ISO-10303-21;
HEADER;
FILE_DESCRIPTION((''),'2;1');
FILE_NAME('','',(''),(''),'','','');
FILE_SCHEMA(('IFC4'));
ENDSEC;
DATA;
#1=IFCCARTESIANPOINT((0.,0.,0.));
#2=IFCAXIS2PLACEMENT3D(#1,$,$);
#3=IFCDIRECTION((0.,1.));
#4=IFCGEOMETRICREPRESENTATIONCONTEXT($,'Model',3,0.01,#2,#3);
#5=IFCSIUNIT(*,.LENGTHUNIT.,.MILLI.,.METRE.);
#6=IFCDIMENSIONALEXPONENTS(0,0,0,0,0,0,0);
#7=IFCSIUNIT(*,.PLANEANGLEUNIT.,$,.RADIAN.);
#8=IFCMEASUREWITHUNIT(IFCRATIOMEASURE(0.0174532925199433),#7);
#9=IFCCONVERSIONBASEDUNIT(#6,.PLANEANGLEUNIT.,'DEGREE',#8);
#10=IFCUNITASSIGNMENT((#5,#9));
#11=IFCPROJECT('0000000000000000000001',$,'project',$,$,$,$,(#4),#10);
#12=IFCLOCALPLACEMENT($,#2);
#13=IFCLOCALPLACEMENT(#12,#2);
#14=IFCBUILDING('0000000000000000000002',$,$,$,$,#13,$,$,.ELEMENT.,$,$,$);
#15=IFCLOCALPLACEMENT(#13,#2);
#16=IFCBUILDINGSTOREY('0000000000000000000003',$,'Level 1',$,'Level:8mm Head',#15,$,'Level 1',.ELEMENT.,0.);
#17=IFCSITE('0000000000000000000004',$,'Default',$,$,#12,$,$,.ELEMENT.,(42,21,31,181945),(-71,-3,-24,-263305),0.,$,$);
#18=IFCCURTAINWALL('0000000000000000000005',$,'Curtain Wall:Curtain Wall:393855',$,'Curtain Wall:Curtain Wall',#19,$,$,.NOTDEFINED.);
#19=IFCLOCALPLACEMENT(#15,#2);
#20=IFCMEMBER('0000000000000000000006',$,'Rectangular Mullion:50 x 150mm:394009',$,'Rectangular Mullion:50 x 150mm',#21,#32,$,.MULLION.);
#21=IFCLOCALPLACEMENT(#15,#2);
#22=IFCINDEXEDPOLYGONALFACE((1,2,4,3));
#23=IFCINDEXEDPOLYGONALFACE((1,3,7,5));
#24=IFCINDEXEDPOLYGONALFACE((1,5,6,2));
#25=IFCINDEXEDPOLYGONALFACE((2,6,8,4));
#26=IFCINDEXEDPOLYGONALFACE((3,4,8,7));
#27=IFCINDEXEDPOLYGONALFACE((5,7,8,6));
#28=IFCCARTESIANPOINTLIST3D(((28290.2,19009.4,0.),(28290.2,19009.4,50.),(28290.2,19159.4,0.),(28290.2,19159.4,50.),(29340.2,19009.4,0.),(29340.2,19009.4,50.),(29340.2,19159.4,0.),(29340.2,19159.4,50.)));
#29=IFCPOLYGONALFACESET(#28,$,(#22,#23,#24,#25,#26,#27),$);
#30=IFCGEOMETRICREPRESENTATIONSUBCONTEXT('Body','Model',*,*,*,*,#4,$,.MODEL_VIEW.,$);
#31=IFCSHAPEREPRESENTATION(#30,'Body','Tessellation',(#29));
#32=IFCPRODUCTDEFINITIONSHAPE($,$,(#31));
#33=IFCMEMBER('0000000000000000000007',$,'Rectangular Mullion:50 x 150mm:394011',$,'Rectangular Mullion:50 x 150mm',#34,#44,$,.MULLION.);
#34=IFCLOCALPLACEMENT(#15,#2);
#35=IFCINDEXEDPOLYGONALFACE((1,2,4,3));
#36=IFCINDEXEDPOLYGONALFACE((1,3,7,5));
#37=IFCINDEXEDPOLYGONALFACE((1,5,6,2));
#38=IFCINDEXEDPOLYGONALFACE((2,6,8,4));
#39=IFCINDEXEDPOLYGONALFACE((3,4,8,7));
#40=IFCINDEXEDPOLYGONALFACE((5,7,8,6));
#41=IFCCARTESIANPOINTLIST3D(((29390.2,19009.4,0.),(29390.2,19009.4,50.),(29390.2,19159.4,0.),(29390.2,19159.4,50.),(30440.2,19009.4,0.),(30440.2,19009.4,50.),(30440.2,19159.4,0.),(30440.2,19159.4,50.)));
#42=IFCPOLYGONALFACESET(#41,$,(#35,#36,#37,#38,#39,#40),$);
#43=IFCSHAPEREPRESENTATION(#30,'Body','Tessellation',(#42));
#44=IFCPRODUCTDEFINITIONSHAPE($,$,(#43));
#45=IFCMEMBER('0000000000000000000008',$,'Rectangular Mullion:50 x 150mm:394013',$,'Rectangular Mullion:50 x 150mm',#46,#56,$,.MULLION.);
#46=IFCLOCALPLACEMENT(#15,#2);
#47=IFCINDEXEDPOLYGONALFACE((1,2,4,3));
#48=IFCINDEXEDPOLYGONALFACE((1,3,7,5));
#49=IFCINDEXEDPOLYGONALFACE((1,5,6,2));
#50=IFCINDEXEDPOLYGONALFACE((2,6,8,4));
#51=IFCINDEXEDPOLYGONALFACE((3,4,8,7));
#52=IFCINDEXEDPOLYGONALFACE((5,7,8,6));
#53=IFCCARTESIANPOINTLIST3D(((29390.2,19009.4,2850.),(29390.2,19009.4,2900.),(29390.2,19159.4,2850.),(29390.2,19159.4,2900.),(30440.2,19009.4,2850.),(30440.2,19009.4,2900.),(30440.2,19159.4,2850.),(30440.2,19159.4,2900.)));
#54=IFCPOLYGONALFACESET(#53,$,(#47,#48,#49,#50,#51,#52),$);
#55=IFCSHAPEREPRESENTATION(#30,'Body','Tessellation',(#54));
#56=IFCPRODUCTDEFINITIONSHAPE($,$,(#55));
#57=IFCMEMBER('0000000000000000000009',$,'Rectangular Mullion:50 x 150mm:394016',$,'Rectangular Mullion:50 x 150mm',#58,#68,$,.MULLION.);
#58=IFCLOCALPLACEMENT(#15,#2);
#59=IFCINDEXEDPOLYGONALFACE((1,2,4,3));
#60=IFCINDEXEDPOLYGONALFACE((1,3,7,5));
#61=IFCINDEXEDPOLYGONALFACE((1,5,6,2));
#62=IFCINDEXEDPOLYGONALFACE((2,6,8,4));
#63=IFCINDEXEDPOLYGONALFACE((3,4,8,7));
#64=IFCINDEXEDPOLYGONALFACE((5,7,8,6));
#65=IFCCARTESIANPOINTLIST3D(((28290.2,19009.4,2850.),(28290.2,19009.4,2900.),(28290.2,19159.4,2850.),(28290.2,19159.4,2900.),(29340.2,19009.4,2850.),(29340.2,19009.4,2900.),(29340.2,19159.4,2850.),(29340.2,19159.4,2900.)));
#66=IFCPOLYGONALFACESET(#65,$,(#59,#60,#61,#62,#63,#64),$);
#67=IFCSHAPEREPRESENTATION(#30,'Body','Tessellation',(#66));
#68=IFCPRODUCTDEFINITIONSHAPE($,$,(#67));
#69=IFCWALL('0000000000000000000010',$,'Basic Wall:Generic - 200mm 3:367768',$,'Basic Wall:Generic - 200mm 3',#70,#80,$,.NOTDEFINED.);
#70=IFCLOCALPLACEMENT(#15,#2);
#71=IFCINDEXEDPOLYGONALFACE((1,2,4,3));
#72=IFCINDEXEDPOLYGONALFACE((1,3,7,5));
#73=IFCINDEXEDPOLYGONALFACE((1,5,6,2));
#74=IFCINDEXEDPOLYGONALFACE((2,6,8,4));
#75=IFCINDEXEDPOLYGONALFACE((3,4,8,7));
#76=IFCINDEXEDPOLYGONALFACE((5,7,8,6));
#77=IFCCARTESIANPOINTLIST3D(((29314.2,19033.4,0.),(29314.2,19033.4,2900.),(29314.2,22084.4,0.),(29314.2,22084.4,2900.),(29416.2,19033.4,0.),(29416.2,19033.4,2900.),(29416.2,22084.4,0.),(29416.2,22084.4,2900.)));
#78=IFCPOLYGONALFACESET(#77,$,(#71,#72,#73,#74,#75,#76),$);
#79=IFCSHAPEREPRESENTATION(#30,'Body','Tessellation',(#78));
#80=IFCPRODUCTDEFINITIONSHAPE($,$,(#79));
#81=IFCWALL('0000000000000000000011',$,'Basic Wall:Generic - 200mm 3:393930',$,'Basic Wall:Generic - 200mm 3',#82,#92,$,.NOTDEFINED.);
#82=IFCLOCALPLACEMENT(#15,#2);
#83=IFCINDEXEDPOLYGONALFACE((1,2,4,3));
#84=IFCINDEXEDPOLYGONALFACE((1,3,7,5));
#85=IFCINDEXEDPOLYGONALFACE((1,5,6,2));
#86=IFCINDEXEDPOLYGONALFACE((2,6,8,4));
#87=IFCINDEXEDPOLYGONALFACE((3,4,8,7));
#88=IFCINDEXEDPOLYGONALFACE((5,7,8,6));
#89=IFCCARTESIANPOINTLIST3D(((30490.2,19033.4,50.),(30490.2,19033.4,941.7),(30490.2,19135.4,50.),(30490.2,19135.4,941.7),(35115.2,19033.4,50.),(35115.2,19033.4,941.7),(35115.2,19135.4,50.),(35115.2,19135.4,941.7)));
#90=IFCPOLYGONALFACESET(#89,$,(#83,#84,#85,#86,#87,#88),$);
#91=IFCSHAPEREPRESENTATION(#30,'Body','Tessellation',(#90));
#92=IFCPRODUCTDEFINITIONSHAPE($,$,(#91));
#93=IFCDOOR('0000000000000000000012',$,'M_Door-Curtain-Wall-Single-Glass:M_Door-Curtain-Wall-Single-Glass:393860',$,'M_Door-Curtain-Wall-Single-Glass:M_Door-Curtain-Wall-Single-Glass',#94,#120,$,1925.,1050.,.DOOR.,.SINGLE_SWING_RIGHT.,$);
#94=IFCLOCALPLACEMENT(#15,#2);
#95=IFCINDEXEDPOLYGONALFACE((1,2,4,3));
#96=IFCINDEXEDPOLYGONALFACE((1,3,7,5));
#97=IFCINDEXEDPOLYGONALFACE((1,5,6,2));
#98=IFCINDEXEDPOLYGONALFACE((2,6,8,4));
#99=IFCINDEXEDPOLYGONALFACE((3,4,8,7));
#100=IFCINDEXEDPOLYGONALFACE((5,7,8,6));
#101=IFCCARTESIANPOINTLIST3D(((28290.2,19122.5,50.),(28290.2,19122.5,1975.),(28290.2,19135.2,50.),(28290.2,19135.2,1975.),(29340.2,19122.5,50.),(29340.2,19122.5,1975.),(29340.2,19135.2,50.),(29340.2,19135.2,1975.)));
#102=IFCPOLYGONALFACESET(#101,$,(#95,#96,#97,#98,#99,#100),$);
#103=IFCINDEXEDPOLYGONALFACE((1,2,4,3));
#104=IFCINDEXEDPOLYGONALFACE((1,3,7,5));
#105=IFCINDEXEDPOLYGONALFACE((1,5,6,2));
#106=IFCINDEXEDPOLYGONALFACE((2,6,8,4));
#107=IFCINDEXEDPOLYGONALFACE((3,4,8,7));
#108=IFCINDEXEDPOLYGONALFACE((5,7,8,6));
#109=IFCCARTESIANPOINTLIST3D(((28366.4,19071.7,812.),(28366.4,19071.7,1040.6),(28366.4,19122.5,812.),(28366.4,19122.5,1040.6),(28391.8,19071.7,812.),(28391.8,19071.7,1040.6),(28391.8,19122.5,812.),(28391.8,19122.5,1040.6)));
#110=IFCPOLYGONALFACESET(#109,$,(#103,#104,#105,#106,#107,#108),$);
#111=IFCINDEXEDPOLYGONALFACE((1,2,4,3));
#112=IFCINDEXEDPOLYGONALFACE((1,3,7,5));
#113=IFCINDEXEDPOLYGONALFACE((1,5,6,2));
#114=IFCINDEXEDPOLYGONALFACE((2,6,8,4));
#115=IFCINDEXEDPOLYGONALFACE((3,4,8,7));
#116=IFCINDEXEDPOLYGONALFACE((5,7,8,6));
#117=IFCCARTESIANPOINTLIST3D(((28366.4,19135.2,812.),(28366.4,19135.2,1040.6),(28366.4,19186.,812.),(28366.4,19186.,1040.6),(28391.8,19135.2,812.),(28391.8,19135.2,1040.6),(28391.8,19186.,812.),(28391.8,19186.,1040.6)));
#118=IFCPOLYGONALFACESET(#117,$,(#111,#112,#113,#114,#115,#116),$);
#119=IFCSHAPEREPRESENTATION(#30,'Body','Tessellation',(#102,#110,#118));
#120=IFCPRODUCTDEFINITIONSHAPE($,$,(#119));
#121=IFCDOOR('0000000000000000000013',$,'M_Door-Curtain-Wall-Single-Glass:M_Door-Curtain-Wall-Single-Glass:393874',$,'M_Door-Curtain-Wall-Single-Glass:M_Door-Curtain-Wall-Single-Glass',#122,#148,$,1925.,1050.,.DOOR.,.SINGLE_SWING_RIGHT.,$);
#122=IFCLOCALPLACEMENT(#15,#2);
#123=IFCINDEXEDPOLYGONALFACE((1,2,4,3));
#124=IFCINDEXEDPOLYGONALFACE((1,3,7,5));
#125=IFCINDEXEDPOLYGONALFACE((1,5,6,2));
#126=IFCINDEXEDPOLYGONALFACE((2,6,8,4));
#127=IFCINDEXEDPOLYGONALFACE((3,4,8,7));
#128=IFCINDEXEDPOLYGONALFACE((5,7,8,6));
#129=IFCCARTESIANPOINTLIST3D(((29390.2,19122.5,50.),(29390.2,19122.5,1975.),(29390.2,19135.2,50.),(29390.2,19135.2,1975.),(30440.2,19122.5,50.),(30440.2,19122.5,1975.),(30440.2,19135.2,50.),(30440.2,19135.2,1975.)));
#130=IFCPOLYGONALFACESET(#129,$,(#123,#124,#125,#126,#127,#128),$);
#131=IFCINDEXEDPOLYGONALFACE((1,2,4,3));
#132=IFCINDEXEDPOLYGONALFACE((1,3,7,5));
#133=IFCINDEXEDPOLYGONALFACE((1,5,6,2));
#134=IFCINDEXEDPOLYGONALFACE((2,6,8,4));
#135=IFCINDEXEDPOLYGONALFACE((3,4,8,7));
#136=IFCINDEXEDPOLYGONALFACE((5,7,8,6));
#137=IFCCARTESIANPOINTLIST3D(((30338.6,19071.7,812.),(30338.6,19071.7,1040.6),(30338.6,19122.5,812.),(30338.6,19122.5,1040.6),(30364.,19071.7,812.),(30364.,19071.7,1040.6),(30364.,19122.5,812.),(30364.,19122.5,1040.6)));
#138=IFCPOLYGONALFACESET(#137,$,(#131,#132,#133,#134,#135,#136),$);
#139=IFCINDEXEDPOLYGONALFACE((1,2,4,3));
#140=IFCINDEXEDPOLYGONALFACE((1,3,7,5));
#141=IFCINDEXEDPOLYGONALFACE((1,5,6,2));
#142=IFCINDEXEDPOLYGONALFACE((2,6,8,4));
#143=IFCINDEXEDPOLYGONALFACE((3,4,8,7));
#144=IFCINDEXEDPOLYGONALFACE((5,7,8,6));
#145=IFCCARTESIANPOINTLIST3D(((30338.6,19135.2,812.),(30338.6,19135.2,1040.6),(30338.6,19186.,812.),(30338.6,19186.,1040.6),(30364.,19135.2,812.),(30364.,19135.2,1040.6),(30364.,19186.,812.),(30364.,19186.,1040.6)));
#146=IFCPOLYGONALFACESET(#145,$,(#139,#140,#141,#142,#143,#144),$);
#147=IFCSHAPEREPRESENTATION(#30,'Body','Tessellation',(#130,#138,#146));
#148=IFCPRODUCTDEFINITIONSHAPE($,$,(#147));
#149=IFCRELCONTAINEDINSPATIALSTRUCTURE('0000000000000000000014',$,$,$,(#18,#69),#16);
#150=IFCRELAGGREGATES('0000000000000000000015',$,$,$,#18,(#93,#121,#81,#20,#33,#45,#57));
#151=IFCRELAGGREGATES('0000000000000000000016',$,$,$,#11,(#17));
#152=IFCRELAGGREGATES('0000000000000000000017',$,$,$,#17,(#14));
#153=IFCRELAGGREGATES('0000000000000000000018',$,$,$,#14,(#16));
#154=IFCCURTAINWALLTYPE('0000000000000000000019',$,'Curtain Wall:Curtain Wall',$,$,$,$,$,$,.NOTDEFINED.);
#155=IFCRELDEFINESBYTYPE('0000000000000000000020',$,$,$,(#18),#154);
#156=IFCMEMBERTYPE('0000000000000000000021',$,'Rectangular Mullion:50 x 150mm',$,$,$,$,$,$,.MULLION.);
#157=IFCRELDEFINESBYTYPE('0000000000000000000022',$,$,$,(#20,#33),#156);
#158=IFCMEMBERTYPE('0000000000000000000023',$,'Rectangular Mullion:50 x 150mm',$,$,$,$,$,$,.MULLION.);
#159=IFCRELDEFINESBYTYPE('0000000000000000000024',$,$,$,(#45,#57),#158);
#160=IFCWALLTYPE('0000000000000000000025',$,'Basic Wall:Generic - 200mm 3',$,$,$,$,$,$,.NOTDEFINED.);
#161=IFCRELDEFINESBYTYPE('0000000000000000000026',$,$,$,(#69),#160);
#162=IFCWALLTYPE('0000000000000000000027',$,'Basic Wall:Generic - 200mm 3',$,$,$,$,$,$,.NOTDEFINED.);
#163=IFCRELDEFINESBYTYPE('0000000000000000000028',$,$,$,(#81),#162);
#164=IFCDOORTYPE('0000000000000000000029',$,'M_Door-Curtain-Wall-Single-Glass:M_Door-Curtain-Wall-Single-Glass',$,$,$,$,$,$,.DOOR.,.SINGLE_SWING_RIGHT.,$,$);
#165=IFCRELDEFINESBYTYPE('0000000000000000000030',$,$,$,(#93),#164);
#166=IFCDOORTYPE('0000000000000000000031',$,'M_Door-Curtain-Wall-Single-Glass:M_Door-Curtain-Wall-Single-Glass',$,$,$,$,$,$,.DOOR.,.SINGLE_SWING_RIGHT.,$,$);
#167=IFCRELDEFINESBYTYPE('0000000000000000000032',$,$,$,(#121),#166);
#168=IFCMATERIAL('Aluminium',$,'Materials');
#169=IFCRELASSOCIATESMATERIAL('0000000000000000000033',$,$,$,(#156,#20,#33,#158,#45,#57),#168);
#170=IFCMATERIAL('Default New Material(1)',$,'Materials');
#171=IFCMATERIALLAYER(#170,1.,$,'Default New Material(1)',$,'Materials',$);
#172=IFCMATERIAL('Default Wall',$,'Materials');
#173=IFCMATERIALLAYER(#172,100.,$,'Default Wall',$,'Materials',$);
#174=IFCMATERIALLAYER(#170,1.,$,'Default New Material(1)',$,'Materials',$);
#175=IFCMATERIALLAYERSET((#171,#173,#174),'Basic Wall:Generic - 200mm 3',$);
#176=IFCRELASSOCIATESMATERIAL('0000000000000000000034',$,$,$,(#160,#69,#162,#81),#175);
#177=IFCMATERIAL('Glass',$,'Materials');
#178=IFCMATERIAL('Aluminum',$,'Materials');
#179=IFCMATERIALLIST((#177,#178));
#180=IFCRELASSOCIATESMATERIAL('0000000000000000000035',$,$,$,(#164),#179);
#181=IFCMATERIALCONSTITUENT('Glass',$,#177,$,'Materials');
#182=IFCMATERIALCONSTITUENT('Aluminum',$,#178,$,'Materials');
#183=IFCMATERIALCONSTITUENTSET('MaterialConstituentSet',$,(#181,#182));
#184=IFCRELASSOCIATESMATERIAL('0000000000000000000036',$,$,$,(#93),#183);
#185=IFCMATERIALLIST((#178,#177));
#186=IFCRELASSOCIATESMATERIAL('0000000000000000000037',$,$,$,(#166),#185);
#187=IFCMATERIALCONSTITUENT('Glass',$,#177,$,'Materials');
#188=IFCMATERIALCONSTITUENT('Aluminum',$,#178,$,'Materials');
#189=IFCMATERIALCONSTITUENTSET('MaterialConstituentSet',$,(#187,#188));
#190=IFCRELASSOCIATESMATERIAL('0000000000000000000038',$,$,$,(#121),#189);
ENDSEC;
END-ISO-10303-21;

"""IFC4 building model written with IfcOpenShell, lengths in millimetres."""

from ifc_helpers import new_model, entity, si_unit, converted_unit, direction, frame, origin, place, context, subcontext, project, spatial, indexed_curve, outline, extrude, source, transform, mapped, material, material_list, layer, layer_set, constituent, constituent_set, type_object, type_shapes, element, aggregate, save


model = new_model("IFC4")

# Units and contexts
model_context = context("Model", 3, precision=0.01, world=origin(), true_north=direction((0.0, 1.0)))
body_context = subcontext(model_context, "Body", "Model", "MODEL_VIEW")
ifc_project = project(units=[si_unit("LENGTHUNIT", "METRE", prefix="MILLI"), converted_unit("PLANEANGLEUNIT", "DEGREE", entity("IfcRatioMeasure", 0.0174532925199433), si_unit("PLANEANGLEUNIT", "RADIAN"), dimensions=[0, 0, 0, 0, 0, 0, 0])], contexts=[model_context])

# Site, building, storey
site_placement = place(None, origin())
site = spatial("IfcSite", under=ifc_project, at=site_placement, Name="Default", CompositionType="ELEMENT", RefLatitude=(42, 21, 31, 181945), RefLongitude=(-71, -3, -24, -263305), RefElevation=0.0)
building_placement = place(site_placement, origin())
building = spatial("IfcBuilding", under=site, at=building_placement, CompositionType="ELEMENT")
storey_placement = place(building_placement, origin())
storey = spatial("IfcBuildingStorey", under=building, at=storey_placement, Name="Level 1", ObjectType="Level:8mm Head", LongName="Level 1", CompositionType="ELEMENT", Elevation=0.0)

# Shared definitions
ifc_material_1 = material(Name="Aluminium", Category="Materials")

# Curtain wall, members
curtain_wall_type_1 = type_object("IfcCurtainWallType", Name="Curtain Wall:Curtain Wall", PredefinedType="NOTDEFINED")
curtain_wall_1_placement = place(storey_placement, origin())
curtain_wall_1 = element("IfcCurtainWall", 1, at=curtain_wall_1_placement, inside=storey, type_object=curtain_wall_type_1, Name="Curtain Wall:Curtain Wall:393855", ObjectType="Curtain Wall:Curtain Wall", PredefinedType="NOTDEFINED")
member_type_1 = type_object("IfcMemberType", Name="Rectangular Mullion:50 x 150mm", PredefinedType="MULLION", material=ifc_material_1)
shared_shape_1 = source(origin(), body_context, "Body", "SweptSolid", [
    extrude(outline(indexed_curve([(-75.0, -25.0), (75.0, -25.0), (75.0, 25.0), (-75.0, 25.0), (-75.0, -25.0)], self_intersect=False)), frame((-25.0, 0.0, -1050.0), z_axis=(0.0, 0.0, 1.0), x_axis=(0.0, -1.0, 0.0)), (0.0, 0.0, 1.0), 1050.0),
])
type_shapes(member_type_1, [shared_shape_1])
member_1_placement = place(storey_placement, frame((28290.2, 19084.4, 0.0), z_axis=(-1.0, 0.0, 0.0), x_axis=(0.0, 0.0, -1.0)))
member_1 = element("IfcMember", 2, at=member_1_placement, type_object=member_type_1, material=ifc_material_1, Name="Rectangular Mullion:50 x 150mm:394009", ObjectType="Rectangular Mullion:50 x 150mm", PredefinedType="MULLION", context=body_context, shape_type="MappedRepresentation", body=[
    mapped(shared_shape_1, transform((0.0, 0.0, 0.0), scale=1.0)),
])
member_2_placement = place(storey_placement, frame((29390.2, 19084.4, 0.0), z_axis=(-1.0, 0.0, 0.0), x_axis=(0.0, 0.0, -1.0)))
member_2 = element("IfcMember", 3, at=member_2_placement, type_object=member_type_1, material=ifc_material_1, Name="Rectangular Mullion:50 x 150mm:394011", ObjectType="Rectangular Mullion:50 x 150mm", PredefinedType="MULLION", context=body_context, shape_type="MappedRepresentation", body=[
    mapped(shared_shape_1, transform((0.0, 0.0, 0.0), scale=1.0)),
])
member_type_2 = type_object("IfcMemberType", Name="Rectangular Mullion:50 x 150mm", PredefinedType="MULLION", material=ifc_material_1)
shared_shape_2 = source(origin(), body_context, "Body", "SweptSolid", [
    extrude(outline(indexed_curve([(-75.0, -25.0), (75.0, -25.0), (75.0, 25.0), (-75.0, 25.0), (-75.0, -25.0)], self_intersect=False)), frame((-25.0, 0.0, -1050.0), z_axis=(0.0, 0.0, 1.0), x_axis=(0.0, -1.0, 0.0)), (0.0, 0.0, 1.0), 1050.0),
])
type_shapes(member_type_2, [shared_shape_2])
member_3_placement = place(storey_placement, frame((30440.2, 19084.4, 2900.0), z_axis=(1.0, 0.0, 0.0), x_axis=(0.0, 0.0, 1.0)))
member_3 = element("IfcMember", 4, at=member_3_placement, type_object=member_type_2, material=ifc_material_1, Name="Rectangular Mullion:50 x 150mm:394013", ObjectType="Rectangular Mullion:50 x 150mm", PredefinedType="MULLION", context=body_context, shape_type="MappedRepresentation", body=[
    mapped(shared_shape_2, transform((0.0, 0.0, 0.0), scale=1.0)),
])
member_4_placement = place(storey_placement, frame((29340.2, 19084.4, 2900.0), z_axis=(1.0, 0.0, 0.0), x_axis=(0.0, 0.0, 1.0)))
member_4 = element("IfcMember", 5, at=member_4_placement, type_object=member_type_2, material=ifc_material_1, Name="Rectangular Mullion:50 x 150mm:394016", ObjectType="Rectangular Mullion:50 x 150mm", PredefinedType="MULLION", context=body_context, shape_type="MappedRepresentation", body=[
    mapped(shared_shape_2, transform((0.0, 0.0, 0.0), scale=1.0)),
])

# Shared definitions
ifc_material_2 = material(Name="Glass", Category="Materials")

# Walls
ifc_material_3 = material(Name="Default New Material(1)", Category="Materials")
ifc_layer_1 = layer(ifc_material_3, 1.0, Name="Default New Material(1)", Category="Materials")
ifc_material_4 = material(Name="Default Wall", Category="Materials")
ifc_layer_2 = layer(ifc_material_4, 100.0, Name="Default Wall", Category="Materials")
ifc_layer_3 = layer(ifc_material_3, 1.0, Name="Default New Material(1)", Category="Materials")
ifc_layer_set = layer_set([ifc_layer_1, ifc_layer_2, ifc_layer_3], Name="Basic Wall:Generic - 200mm 3")
wall_type_1 = type_object("IfcWallType", Name="Basic Wall:Generic - 200mm 3", PredefinedType="NOTDEFINED", material=ifc_layer_set)
wall_1_placement = place(storey_placement, frame((29365.2, 22084.4, 0.0), z_axis=(0.0, 0.0, 1.0), x_axis=(0.0, -1.0, 0.0)))
element("IfcWall", 6, at=wall_1_placement, inside=storey, type_object=wall_type_1, material=ifc_layer_set, Name="Basic Wall:Generic - 200mm 3:367768", ObjectType="Basic Wall:Generic - 200mm 3", PredefinedType="NOTDEFINED", context=body_context, shape_type="SweptSolid", body=[
    extrude(outline(indexed_curve([(3051.0, 51.0), (0.0, 51.0), (0.0, -51.0), (3051.0, -51.0), (3051.0, 51.0)], self_intersect=False)), origin(), (0.0, 0.0, 1.0), 2900.0),
])
wall_type_2 = type_object("IfcWallType", Name="Basic Wall:Generic - 200mm 3", PredefinedType="NOTDEFINED", material=ifc_layer_set)
wall_2_placement = place(storey_placement, frame((30490.2, 19084.4, 50.0)))
wall_2 = element("IfcWall", 7, at=wall_2_placement, type_object=wall_type_2, material=ifc_layer_set, Name="Basic Wall:Generic - 200mm 3:393930", ObjectType="Basic Wall:Generic - 200mm 3", PredefinedType="NOTDEFINED", context=body_context, shape_type="SweptSolid", body=[
    extrude(outline(indexed_curve([(4625.0, 51.0), (0.0, 51.0), (0.0, -51.0), (4625.0, -51.0), (4625.0, 51.0)], self_intersect=False)), origin(), (0.0, 0.0, 1.0), 891.7),
])

# Doors
ifc_constituent_1 = constituent(ifc_material_2, Name="Glass", Category="Materials")
ifc_material_5 = material(Name="Aluminum", Category="Materials")
ifc_constituent_2 = constituent(ifc_material_5, Name="Aluminum", Category="Materials")
ifc_constituent_set_1 = constituent_set(constituents=[ifc_constituent_1, ifc_constituent_2], Name="MaterialConstituentSet")
ifc_material_list_1 = material_list([ifc_material_2, ifc_material_5])
door_type_1 = type_object("IfcDoorType", Name="M_Door-Curtain-Wall-Single-Glass:M_Door-Curtain-Wall-Single-Glass", OperationType="SINGLE_SWING_RIGHT", PredefinedType="DOOR", material=ifc_material_list_1)
shared_shape_3 = source(origin(), body_context, "Body", "SweptSolid", [
    extrude(outline(indexed_curve([(-525.0, -6.4), (525.0, -6.4), (525.0, 6.4), (-525.0, 6.4), (-525.0, -6.4)], self_intersect=False)), frame((0.0, 44.5, 0.0), z_axis=(0.0, 0.0, 1.0), x_axis=(-1.0, 0.0, 0.0)), (0.0, 0.0, 1.0), 1925.0),
    extrude(outline(indexed_curve([(-25.4, -12.7), (25.4, -12.7), (25.4, 12.7), (-25.4, 12.7), (-25.4, -12.7)], self_intersect=False)), frame((-436.1, 12.7, 762.0), z_axis=(0.0, 0.0, 1.0), x_axis=(0.0, 1.0, 0.0)), (0.0, 0.0, 1.0), 228.6),
    extrude(outline(indexed_curve([(-25.4, -12.7), (25.4, -12.7), (25.4, 12.7), (-25.4, 12.7), (-25.4, -12.7)], self_intersect=False)), frame((-436.1, 76.2, 762.0), z_axis=(0.0, 0.0, 1.0), x_axis=(0.0, -1.0, 0.0)), (0.0, 0.0, 1.0), 228.6),
])
type_shapes(door_type_1, [shared_shape_3])
door_1_placement = place(curtain_wall_1_placement, frame((28815.2, 19084.4, 50.0)))
door_1 = element("IfcDoor", 8, at=door_1_placement, type_object=door_type_1, material=ifc_constituent_set_1, Name="M_Door-Curtain-Wall-Single-Glass:M_Door-Curtain-Wall-Single-Glass:393860", ObjectType="M_Door-Curtain-Wall-Single-Glass:M_Door-Curtain-Wall-Single-Glass", OperationType="SINGLE_SWING_RIGHT", OverallHeight=1925.0, OverallWidth=1050.0, PredefinedType="DOOR", context=body_context, shape_type="MappedRepresentation", body=[
    mapped(shared_shape_3, transform((0.0, 0.0, 0.0), scale=1.0)),
])
ifc_constituent_3 = constituent(ifc_material_2, Name="Glass", Category="Materials")
ifc_constituent_4 = constituent(ifc_material_5, Name="Aluminum", Category="Materials")
ifc_constituent_set_2 = constituent_set(constituents=[ifc_constituent_3, ifc_constituent_4], Name="MaterialConstituentSet")
ifc_material_list_2 = material_list([ifc_material_5, ifc_material_2])
door_type_2 = type_object("IfcDoorType", Name="M_Door-Curtain-Wall-Single-Glass:M_Door-Curtain-Wall-Single-Glass", OperationType="SINGLE_SWING_RIGHT", PredefinedType="DOOR", material=ifc_material_list_2)
shared_shape_4 = source(origin(), body_context, "Body", "SweptSolid", [
    extrude(outline(indexed_curve([(-6.4, -525.0), (6.4, -525.0), (6.4, 525.0), (-6.4, 525.0), (-6.4, -525.0)], self_intersect=False)), frame((0.0, -44.5, 0.0), z_axis=(0.0, 0.0, 1.0), x_axis=(0.0, 1.0, 0.0)), (0.0, 0.0, 1.0), 1925.0),
    extrude(outline(indexed_curve([(-12.7, -25.4), (12.7, -25.4), (12.7, 25.4), (-12.7, 25.4), (-12.7, -25.4)], self_intersect=False)), frame((-436.1, -12.7, 762.0), z_axis=(0.0, 0.0, 1.0), x_axis=(-1.0, 0.0, 0.0)), (0.0, 0.0, 1.0), 228.6),
    extrude(outline(indexed_curve([(-12.7, -25.4), (12.7, -25.4), (12.7, 25.4), (-12.7, 25.4), (-12.7, -25.4)], self_intersect=False)), frame((-436.1, -76.2, 762.0)), (0.0, 0.0, 1.0), 228.6),
])
type_shapes(door_type_2, [shared_shape_4])
door_2_placement = place(curtain_wall_1_placement, frame((29915.2, 19084.4, 50.0), z_axis=(0.0, 0.0, 1.0), x_axis=(-1.0, 0.0, 0.0)))
door_2 = element("IfcDoor", 9, at=door_2_placement, type_object=door_type_2, material=ifc_constituent_set_2, Name="M_Door-Curtain-Wall-Single-Glass:M_Door-Curtain-Wall-Single-Glass:393874", ObjectType="M_Door-Curtain-Wall-Single-Glass:M_Door-Curtain-Wall-Single-Glass", OperationType="SINGLE_SWING_RIGHT", OverallHeight=1925.0, OverallWidth=1050.0, PredefinedType="DOOR", context=body_context, shape_type="MappedRepresentation", body=[
    mapped(shared_shape_4, transform((0.0, 0.0, 0.0), scale=1.0)),
])
aggregate(curtain_wall_1, [door_1, door_2, wall_2, member_1, member_2, member_3, member_4])

save(model, "model.ifc")
